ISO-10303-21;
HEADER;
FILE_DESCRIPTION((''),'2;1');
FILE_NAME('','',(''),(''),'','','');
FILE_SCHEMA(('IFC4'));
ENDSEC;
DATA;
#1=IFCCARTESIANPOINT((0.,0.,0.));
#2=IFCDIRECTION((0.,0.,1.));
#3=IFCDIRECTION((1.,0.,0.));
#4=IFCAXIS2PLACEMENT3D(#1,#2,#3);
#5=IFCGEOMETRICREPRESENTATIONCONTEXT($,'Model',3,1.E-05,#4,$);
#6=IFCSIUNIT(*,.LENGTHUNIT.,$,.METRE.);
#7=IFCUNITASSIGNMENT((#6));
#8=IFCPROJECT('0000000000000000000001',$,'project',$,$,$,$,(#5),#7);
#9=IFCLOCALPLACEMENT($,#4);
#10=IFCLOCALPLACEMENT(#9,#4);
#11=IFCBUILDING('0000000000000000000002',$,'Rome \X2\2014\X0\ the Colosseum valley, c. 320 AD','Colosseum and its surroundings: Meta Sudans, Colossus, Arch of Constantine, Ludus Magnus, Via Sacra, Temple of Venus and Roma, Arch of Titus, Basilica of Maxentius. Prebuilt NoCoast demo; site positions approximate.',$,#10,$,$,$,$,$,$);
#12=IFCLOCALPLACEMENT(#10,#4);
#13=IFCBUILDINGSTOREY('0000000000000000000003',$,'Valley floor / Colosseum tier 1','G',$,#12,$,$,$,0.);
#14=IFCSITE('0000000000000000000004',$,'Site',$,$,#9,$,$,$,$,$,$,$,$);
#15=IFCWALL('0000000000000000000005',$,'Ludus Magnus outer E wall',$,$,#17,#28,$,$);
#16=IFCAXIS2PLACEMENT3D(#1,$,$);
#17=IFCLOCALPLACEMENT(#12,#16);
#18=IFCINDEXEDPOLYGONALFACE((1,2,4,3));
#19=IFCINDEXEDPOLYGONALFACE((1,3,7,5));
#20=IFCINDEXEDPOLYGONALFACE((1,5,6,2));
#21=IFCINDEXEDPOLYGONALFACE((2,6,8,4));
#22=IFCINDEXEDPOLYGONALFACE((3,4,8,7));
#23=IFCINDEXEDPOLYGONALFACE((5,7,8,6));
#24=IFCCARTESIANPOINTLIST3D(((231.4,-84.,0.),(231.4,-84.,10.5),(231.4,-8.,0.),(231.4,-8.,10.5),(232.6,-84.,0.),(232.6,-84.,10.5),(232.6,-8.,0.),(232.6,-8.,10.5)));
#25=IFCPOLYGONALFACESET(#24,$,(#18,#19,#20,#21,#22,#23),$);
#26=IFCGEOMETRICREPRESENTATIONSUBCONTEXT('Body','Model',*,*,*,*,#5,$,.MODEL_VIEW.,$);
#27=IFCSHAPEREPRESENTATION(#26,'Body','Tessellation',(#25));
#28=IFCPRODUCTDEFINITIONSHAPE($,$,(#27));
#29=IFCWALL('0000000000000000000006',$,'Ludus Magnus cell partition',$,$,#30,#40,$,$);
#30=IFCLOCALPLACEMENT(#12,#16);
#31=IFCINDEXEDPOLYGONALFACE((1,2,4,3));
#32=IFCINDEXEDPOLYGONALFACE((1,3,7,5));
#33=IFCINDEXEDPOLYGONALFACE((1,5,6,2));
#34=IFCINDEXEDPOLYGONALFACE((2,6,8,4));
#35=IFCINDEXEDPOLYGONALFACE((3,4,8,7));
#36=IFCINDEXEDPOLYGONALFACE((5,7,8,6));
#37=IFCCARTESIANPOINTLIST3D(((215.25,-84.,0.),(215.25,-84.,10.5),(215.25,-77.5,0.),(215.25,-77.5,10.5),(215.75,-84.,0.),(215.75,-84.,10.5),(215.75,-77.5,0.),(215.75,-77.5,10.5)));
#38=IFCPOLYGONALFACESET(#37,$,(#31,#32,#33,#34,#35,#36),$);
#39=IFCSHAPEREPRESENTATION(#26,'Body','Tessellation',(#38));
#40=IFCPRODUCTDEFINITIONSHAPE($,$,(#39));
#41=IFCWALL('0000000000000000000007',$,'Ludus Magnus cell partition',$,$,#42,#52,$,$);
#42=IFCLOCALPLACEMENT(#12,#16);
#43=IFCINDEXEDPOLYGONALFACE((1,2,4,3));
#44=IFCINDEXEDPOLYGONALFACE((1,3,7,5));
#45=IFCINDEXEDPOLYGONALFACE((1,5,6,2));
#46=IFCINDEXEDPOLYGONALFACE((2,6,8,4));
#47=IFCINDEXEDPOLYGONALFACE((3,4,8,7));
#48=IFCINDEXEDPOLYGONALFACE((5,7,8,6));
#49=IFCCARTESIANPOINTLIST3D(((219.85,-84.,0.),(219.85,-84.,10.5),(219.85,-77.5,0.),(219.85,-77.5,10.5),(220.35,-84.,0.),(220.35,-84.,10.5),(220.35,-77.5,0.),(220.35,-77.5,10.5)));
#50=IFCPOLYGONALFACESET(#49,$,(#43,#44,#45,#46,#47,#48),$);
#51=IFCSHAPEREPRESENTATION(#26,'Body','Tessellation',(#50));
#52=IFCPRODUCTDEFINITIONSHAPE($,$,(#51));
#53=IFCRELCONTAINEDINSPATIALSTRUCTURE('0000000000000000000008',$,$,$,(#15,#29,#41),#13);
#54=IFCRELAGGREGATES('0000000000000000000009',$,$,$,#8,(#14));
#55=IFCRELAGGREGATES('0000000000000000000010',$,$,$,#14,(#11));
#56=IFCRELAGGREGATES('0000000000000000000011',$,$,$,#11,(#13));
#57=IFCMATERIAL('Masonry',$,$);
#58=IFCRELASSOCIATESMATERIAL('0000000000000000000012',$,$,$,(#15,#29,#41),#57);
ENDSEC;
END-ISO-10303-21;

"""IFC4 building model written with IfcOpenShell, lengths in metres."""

from ifc_helpers import new_model, si_unit, frame, origin_with_axes, place, context, subcontext, project, spatial, indexed_curve, outline, extrude, material, element, save


model = new_model("IFC4")

# Units and contexts
model_context = context("Model", 3, precision=1e-05, world=origin_with_axes())
body_context = subcontext(model_context, "Body", "Model", "MODEL_VIEW")
ifc_project = project(units=[si_unit("LENGTHUNIT", "METRE")], contexts=[model_context])

# Site, building, storey
site_placement = place(None, origin_with_axes())
site = spatial("IfcSite", under=ifc_project, at=site_placement, Name="Site")
building_placement = place(site_placement, origin_with_axes())
building = spatial("IfcBuilding", under=site, at=building_placement, Name="Rome — the Colosseum valley, c. 320 AD", Description="Colosseum and its surroundings: Meta Sudans, Colossus, Arch of Constantine, Ludus Magnus, Via Sacra, Temple of Venus and Roma, Arch of Titus, Basilica of Maxentius. Prebuilt NoCoast demo; site positions approximate.")
storey_placement = place(building_placement, origin_with_axes())
storey = spatial("IfcBuildingStorey", under=building, at=storey_placement, Name="Valley floor / Colosseum tier 1", Description="G", Elevation=0.0)

# Walls
ifc_material = material(Name="Masonry")
wall_placement = place(storey_placement, frame((232.0, -84.0, 0.0), z_axis=(0.0, 0.0, 1.0), x_axis=(0.0, 1.0, 0.0)))
element("IfcWall", 1, at=wall_placement, inside=storey, material=ifc_material, Name="Ludus Magnus outer E wall", context=body_context, shape_type="SweptSolid", body=[
    extrude(outline(indexed_curve([(0.0, 0.0), (0.0, 1.2), (76.0, 1.2), (76.0, 0.0), (0.0, 0.0)], self_intersect=False)), frame((0.0, -0.6, 0.0), z_axis=(0.0, 0.0, 1.0), x_axis=(1.0, 0.0, 0.0)), (0.0, 0.0, 1.0), 10.5),
])
for number, where, z_axis, x_axis, name in (
    (2, (215.5, -84.0, 0.0), (0.0, 0.0, 1.0), (0.0, 1.0, 0.0), "Ludus Magnus cell partition"),
    (3, (220.1, -84.0, 0.0), (0.0, 0.0, 1.0), (0.0, 1.0, 0.0), "Ludus Magnus cell partition"),
):
    element("IfcWall", number, at=place(storey_placement, frame(where, z_axis=z_axis, x_axis=x_axis)), inside=storey, material=ifc_material, Name=name, context=body_context, shape_type="SweptSolid", body=[
        extrude(outline(indexed_curve([(0.0, 0.0), (0.0, 0.5), (6.5, 0.5), (6.5, 0.0), (0.0, 0.0)], self_intersect=False)), frame((0.0, -0.25, 0.0), z_axis=(0.0, 0.0, 1.0), x_axis=(1.0, 0.0, 0.0)), (0.0, 0.0, 1.0), 10.5),
    ])

save(model, "model.ifc")
